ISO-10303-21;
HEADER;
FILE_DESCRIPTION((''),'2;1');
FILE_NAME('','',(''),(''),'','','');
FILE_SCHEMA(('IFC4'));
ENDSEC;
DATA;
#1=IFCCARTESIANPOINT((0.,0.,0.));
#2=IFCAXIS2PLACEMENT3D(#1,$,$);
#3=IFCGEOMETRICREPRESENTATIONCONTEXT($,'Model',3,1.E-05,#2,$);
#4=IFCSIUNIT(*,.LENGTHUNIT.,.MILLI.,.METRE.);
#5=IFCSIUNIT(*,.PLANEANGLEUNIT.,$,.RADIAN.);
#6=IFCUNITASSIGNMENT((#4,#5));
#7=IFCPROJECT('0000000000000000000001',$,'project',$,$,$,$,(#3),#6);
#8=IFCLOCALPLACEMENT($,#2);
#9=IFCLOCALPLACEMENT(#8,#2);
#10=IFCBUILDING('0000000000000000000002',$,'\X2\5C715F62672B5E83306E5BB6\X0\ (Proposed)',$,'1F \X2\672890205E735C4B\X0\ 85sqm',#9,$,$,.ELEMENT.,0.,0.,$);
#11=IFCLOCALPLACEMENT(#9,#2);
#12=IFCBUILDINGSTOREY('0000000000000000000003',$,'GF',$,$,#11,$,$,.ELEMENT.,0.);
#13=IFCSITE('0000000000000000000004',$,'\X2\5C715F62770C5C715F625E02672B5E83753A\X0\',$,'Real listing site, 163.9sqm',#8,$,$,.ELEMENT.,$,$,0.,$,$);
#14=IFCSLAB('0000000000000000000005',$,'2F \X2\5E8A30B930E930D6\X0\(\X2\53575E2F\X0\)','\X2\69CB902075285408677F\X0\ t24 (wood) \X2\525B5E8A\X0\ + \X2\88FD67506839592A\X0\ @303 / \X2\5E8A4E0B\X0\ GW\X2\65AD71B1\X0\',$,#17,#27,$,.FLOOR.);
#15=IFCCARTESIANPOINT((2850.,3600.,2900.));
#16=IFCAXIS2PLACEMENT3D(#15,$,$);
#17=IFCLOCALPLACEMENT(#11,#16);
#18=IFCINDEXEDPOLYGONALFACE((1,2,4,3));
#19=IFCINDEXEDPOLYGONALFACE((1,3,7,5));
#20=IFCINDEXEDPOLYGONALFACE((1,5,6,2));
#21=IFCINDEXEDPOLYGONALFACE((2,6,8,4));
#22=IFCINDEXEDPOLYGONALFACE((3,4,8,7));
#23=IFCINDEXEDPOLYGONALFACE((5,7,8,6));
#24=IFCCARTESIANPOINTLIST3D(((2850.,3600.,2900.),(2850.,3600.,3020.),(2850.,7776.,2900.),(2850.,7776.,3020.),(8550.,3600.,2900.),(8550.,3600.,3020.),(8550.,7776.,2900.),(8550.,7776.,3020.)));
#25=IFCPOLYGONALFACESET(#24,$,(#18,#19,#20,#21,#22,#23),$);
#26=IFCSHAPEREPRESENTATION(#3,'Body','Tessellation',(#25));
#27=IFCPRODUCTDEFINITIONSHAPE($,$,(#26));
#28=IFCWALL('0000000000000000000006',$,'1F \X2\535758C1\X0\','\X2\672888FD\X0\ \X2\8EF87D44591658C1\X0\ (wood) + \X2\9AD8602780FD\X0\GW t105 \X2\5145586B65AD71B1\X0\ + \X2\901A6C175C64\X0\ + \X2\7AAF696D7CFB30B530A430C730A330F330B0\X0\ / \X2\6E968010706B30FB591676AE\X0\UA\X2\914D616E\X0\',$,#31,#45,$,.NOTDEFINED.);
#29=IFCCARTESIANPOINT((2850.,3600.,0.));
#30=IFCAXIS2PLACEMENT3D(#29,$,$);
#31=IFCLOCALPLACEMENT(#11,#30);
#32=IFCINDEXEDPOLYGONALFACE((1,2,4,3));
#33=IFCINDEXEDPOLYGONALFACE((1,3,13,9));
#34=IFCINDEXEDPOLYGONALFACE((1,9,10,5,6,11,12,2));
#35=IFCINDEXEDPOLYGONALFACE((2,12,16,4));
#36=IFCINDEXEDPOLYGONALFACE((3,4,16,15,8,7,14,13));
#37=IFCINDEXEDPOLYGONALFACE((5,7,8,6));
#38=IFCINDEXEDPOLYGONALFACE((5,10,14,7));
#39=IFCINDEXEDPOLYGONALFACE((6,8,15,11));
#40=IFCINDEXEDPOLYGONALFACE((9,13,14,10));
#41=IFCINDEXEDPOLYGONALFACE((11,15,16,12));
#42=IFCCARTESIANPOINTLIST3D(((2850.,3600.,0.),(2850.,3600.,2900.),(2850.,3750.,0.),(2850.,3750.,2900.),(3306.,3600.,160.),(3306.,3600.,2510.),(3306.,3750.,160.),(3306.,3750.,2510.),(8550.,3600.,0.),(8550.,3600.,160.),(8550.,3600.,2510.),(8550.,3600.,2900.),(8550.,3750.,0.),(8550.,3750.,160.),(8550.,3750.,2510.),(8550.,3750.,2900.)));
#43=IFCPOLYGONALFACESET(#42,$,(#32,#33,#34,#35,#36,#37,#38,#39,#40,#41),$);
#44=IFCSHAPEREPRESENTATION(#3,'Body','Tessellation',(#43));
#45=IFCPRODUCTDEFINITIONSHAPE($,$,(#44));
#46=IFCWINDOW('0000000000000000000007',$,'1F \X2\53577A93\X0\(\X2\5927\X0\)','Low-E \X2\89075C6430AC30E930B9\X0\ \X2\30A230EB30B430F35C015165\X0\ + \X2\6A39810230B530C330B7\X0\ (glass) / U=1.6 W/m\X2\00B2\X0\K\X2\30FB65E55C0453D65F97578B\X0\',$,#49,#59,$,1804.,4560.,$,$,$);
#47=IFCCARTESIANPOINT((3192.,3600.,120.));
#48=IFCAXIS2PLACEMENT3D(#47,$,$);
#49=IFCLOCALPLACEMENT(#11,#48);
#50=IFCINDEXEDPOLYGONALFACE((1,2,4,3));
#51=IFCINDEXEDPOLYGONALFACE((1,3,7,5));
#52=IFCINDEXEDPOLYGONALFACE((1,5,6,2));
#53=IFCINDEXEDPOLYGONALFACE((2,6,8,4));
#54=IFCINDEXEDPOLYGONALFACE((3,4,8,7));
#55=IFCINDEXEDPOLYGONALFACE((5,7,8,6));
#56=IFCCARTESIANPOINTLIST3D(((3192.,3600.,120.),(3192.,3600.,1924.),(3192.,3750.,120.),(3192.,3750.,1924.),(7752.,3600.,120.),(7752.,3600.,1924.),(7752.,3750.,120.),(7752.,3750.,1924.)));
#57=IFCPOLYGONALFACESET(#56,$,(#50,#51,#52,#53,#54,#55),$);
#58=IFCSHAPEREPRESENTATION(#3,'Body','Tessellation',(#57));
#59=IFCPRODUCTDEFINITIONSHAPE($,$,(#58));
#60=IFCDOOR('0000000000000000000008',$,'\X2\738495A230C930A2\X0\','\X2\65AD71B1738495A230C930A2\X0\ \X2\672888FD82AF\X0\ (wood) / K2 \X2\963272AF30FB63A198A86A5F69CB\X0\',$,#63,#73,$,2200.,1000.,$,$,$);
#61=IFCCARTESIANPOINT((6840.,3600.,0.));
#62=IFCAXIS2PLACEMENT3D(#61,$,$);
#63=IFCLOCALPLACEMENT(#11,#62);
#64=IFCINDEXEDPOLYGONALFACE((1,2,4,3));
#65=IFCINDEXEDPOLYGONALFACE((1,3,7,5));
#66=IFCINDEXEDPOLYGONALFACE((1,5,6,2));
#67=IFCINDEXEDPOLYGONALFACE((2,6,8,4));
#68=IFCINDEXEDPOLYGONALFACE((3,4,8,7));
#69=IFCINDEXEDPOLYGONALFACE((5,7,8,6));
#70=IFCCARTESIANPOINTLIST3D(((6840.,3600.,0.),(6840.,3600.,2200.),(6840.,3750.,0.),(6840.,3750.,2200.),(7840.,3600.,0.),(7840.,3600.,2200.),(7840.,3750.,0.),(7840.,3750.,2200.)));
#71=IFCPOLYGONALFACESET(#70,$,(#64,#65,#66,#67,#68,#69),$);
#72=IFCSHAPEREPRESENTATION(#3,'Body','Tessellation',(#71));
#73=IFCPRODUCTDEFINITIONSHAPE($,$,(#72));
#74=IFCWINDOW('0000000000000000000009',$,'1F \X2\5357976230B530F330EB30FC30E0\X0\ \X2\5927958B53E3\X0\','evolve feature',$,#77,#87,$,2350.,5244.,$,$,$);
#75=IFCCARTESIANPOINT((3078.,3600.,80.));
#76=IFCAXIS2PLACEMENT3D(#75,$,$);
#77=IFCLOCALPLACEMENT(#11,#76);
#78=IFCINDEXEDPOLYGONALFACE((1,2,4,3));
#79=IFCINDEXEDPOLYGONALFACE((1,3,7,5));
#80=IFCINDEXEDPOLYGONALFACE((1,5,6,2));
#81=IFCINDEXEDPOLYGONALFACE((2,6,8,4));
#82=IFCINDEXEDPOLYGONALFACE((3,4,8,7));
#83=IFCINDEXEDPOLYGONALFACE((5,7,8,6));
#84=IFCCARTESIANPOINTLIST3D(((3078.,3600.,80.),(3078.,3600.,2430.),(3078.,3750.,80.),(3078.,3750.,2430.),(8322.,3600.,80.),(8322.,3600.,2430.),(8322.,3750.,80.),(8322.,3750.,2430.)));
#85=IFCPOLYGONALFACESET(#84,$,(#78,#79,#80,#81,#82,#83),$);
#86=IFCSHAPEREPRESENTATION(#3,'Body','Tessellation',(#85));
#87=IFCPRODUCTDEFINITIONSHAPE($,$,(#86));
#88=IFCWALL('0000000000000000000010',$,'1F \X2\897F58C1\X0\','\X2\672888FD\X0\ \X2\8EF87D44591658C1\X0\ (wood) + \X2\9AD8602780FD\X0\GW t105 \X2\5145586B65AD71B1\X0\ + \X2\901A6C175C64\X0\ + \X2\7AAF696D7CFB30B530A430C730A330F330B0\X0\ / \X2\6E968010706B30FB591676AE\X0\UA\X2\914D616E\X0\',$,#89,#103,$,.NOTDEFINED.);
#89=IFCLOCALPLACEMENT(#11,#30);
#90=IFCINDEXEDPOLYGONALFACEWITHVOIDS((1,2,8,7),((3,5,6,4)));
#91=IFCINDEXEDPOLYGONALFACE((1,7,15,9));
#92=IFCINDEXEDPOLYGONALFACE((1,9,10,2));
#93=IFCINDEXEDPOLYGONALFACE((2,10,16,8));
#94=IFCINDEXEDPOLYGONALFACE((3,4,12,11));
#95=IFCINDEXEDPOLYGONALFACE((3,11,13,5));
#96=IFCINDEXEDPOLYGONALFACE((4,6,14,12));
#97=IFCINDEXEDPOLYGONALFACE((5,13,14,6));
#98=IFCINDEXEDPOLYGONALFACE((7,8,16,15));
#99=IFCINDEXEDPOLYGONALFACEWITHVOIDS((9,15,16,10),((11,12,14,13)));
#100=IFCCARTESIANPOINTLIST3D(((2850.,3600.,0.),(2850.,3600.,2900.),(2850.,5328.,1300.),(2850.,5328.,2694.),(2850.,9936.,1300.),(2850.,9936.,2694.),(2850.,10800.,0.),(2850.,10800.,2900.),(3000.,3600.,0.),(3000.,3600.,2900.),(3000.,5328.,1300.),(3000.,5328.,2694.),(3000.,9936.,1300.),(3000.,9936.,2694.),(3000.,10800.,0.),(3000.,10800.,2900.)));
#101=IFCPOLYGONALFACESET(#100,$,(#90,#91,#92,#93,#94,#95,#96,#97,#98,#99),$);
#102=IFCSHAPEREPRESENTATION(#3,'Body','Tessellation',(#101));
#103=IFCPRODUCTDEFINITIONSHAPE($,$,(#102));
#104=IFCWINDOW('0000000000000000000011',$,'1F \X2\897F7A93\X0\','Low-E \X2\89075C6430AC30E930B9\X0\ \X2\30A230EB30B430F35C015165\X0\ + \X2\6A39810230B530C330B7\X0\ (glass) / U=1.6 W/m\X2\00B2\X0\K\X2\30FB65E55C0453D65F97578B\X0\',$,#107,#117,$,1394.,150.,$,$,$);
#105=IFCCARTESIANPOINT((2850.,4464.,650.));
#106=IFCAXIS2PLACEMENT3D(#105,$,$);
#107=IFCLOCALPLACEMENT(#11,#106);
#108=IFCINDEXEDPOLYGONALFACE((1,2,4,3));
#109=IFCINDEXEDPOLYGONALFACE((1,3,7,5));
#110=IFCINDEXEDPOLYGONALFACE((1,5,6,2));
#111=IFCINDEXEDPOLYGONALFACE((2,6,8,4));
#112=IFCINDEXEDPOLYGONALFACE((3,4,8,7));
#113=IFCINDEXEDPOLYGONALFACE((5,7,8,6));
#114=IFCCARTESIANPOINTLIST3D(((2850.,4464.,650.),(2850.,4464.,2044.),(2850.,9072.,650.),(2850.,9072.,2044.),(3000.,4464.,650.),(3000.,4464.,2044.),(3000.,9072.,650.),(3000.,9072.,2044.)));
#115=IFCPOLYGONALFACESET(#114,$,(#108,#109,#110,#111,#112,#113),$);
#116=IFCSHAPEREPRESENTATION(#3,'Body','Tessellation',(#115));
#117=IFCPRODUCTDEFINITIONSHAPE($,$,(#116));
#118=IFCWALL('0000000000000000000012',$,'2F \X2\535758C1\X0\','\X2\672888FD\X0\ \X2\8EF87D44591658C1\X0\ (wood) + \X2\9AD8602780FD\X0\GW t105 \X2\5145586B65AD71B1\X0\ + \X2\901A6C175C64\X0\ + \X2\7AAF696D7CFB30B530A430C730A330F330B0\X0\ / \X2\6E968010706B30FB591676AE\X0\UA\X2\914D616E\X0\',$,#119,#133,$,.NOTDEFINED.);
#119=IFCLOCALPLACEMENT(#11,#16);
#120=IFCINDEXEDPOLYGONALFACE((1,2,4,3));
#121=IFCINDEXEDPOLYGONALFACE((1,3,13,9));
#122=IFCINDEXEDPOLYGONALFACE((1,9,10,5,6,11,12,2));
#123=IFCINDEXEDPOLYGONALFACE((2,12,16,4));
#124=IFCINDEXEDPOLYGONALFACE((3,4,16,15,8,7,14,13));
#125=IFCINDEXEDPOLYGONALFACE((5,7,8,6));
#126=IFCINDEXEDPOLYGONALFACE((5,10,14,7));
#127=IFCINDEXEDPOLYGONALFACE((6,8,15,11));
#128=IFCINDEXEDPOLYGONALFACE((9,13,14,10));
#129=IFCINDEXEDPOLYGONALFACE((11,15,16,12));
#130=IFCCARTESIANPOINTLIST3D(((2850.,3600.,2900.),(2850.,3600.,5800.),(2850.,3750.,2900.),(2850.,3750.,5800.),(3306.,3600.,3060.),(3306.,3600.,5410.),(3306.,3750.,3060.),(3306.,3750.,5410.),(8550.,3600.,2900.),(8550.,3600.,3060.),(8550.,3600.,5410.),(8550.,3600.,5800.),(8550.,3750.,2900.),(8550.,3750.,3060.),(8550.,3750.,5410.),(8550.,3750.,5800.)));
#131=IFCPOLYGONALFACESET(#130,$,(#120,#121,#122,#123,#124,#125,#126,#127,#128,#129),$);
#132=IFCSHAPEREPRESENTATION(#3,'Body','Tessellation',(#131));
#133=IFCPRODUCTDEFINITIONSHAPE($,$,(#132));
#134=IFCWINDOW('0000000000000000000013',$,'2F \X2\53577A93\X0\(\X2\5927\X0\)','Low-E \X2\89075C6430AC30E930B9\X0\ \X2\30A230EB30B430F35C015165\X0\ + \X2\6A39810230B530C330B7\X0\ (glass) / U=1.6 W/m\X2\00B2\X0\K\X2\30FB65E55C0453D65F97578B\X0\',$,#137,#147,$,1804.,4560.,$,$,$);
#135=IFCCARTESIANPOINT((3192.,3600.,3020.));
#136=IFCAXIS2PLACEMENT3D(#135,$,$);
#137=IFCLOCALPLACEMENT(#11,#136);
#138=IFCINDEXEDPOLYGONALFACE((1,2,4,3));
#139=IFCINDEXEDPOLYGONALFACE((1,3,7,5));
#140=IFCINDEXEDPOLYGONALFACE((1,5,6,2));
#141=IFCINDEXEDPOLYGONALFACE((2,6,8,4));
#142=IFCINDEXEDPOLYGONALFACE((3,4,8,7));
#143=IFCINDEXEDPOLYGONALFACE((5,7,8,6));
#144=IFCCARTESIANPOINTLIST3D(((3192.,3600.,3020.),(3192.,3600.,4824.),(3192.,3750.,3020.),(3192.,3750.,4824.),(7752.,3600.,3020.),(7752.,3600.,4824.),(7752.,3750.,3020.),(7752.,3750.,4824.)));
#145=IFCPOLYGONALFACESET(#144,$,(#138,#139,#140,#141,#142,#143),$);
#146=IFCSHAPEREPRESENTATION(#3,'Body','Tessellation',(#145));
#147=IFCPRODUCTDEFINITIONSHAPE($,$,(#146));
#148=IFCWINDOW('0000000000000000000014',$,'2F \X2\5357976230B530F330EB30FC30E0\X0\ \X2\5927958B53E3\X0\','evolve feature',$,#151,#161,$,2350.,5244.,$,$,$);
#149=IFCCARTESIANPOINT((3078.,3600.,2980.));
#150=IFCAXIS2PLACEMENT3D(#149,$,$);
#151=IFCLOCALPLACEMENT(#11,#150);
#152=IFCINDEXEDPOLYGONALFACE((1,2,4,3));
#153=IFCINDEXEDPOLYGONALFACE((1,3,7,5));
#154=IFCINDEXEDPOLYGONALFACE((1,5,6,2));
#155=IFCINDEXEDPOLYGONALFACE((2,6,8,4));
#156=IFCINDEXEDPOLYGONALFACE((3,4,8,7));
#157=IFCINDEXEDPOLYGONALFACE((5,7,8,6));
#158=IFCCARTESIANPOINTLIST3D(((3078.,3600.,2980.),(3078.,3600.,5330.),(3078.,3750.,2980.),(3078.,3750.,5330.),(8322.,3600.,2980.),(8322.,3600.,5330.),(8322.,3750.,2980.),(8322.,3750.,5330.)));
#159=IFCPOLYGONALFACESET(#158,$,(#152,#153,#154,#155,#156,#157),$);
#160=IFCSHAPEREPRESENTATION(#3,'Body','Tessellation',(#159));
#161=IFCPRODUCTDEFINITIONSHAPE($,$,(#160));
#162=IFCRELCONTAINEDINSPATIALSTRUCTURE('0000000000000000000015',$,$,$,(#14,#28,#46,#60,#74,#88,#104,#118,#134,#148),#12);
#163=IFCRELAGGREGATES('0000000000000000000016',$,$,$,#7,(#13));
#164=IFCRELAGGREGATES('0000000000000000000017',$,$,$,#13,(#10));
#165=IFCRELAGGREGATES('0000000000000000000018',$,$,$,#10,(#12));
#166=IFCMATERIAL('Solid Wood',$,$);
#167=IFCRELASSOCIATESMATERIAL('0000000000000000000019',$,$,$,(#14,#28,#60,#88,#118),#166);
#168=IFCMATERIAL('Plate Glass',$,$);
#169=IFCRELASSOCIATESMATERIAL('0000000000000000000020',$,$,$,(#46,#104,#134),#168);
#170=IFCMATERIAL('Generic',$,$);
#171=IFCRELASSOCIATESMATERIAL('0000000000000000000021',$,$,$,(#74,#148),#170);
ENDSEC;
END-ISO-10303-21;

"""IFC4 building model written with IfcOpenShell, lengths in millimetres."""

from ifc_helpers import new_model, si_unit, frame, frame_2d, origin, place, context, project, spatial, rectangle, extrude, material, element, fill, save


model = new_model("IFC4")

# Units and contexts
model_context = context("Model", 3, precision=1e-05, world=origin())
ifc_project = project(units=[si_unit("LENGTHUNIT", "METRE", prefix="MILLI"), si_unit("PLANEANGLEUNIT", "RADIAN")], contexts=[model_context])

# Site, building, storey
site_placement = place(None, origin())
site = spatial("IfcSite", under=ifc_project, at=site_placement, Name="山形県山形市末広町", ObjectType="Real listing site, 163.9sqm", CompositionType="ELEMENT", RefElevation=0.0)
building_placement = place(site_placement, origin())
building = spatial("IfcBuilding", under=site, at=building_placement, Name="山形末広の家 (Proposed)", ObjectType="1F 木造平屋 85sqm", CompositionType="ELEMENT", ElevationOfRefHeight=0.0, ElevationOfTerrain=0.0)
storey_placement = place(building_placement, origin())
storey = spatial("IfcBuildingStorey", under=building, at=storey_placement, Name="GF", CompositionType="ELEMENT", Elevation=0.0)

# Slab
ifc_material_1 = material(Name="Solid Wood")
slab_1_placement = place(storey_placement, frame((2850.0, 3600.0, 2900.0)))
element("IfcSlab", 1, at=slab_1_placement, inside=storey, material=ifc_material_1, Name="2F 床スラブ(南帯)", Description="構造用合板 t24 (wood) 剛床 + 製材根太 @303 / 床下 GW断熱", PredefinedType="FLOOR", context=model_context, shape_type="SweptSolid", body=[
    extrude(rectangle(XDim=5700.0, YDim=4176.0, at=frame_2d((2850.0, 2088.0))), frame((2850.0, 3600.0, 2900.0)), (0.0, 0.0, 1.0), 120.0),
])
ifc_material_2 = material(Name="Generic")

# Wall, openings, windows, door
wall_1_placement = place(storey_placement, frame((2850.0, 3600.0, 0.0)))
wall_1 = element("IfcWall", 2, at=wall_1_placement, inside=storey, material=ifc_material_1, Name="1F 南壁", Description="木製 軸組外壁 (wood) + 高性能GW t105 充填断熱 + 通気層 + 窯業系サイディング / 準耐火・外皮UA配慮", PredefinedType="NOTDEFINED", context=model_context, shape_type="SweptSolid", body=[
    extrude(rectangle(XDim=5700.0, YDim=150.0, at=frame_2d((2850.0, 75.0))), frame((2850.0, 3600.0, 0.0)), (0.0, 0.0, 1.0), 2900.0),
])
opening_1_placement = place(storey_placement, frame((3192.0, 3600.0, 120.0)))
opening_1 = element("IfcOpeningElement", 3, at=opening_1_placement, cuts=wall_1, PredefinedType="NOTDEFINED", context=model_context, shape_type="SweptSolid", body=[
    extrude(rectangle(XDim=4560.0, YDim=150.0, at=frame_2d((2280.0, 75.0))), frame((3192.0, 3600.0, 120.0)), (0.0, 0.0, 1.0), 1804.0),
])
opening_2_placement = place(storey_placement, frame((6840.0, 3600.0, 0.0)))
opening_2 = element("IfcOpeningElement", 4, at=opening_2_placement, cuts=wall_1, PredefinedType="NOTDEFINED", context=model_context, shape_type="SweptSolid", body=[
    extrude(rectangle(XDim=1000.0, YDim=150.0, at=frame_2d((500.0, 75.0))), frame((6840.0, 3600.0, 0.0)), (0.0, 0.0, 1.0), 2200.0),
])
opening_3_placement = place(storey_placement, frame((3078.0, 3600.0, 80.0)))
opening_3 = element("IfcOpeningElement", 5, at=opening_3_placement, cuts=wall_1, PredefinedType="NOTDEFINED", context=model_context, shape_type="SweptSolid", body=[
    extrude(rectangle(XDim=5244.0, YDim=150.0, at=frame_2d((2622.0, 75.0))), frame((3078.0, 3600.0, 80.0)), (0.0, 0.0, 1.0), 2350.0),
])
ifc_material_3 = material(Name="Plate Glass")
window_1_placement = place(storey_placement, frame((3192.0, 3600.0, 120.0)))
window_1 = element("IfcWindow", 6, at=window_1_placement, inside=storey, material=ifc_material_3, Name="1F 南窓(大)", Description="Low-E 複層ガラス アルゴン封入 + 樹脂サッシ (glass) / U=1.6 W/m²K・日射取得型", OverallHeight=1804.0, OverallWidth=4560.0, context=model_context, shape_type="SweptSolid", body=[
    extrude(rectangle(XDim=4560.0, YDim=150.0, at=frame_2d((2280.0, 75.0))), frame((3192.0, 3600.0, 120.0)), (0.0, 0.0, 1.0), 1804.0),
])
fill(opening_1, window_1)
door_placement = place(storey_placement, frame((6840.0, 3600.0, 0.0)))
door = element("IfcDoor", 7, at=door_placement, inside=storey, material=ifc_material_1, Name="玄関ドア", Description="断熱玄関ドア 木製芯 (wood) / K2 防犯・採風機構", OverallHeight=2200.0, OverallWidth=1000.0, context=model_context, shape_type="SweptSolid", body=[
    extrude(rectangle(XDim=1000.0, YDim=150.0, at=frame_2d((500.0, 75.0))), frame((6840.0, 3600.0, 0.0)), (0.0, 0.0, 1.0), 2200.0),
])
fill(opening_2, door)
window_2_placement = place(storey_placement, frame((3078.0, 3600.0, 80.0)))
window_2 = element("IfcWindow", 8, at=window_2_placement, inside=storey, material=ifc_material_2, Name="1F 南面サンルーム 大開口", Description="evolve feature", OverallHeight=2350.0, OverallWidth=5244.0, context=model_context, shape_type="SweptSolid", body=[
    extrude(rectangle(XDim=5244.0, YDim=150.0, at=frame_2d((2622.0, 75.0))), frame((3078.0, 3600.0, 80.0)), (0.0, 0.0, 1.0), 2350.0),
])
fill(opening_3, window_2)

# Wall, opening, window
wall_2_placement = place(storey_placement, frame((2850.0, 3600.0, 0.0)))
wall_2 = element("IfcWall", 9, at=wall_2_placement, inside=storey, material=ifc_material_1, Name="1F 西壁", Description="木製 軸組外壁 (wood) + 高性能GW t105 充填断熱 + 通気層 + 窯業系サイディング / 準耐火・外皮UA配慮", PredefinedType="NOTDEFINED", context=model_context, shape_type="SweptSolid", body=[
    extrude(rectangle(XDim=150.0, YDim=7200.0, at=frame_2d((75.0, 3600.0))), frame((2850.0, 3600.0, 0.0)), (0.0, 0.0, 1.0), 2900.0),
])
opening_4_placement = place(storey_placement, frame((2850.0, 4464.0, 650.0)))
opening_4 = element("IfcOpeningElement", 10, at=opening_4_placement, cuts=wall_2, PredefinedType="NOTDEFINED", context=model_context, shape_type="SweptSolid", body=[
    extrude(rectangle(XDim=150.0, YDim=4608.0, at=frame_2d((75.0, 2304.0))), frame((2850.0, 4464.0, 650.0)), (0.0, 0.0, 1.0), 1394.0),
])
window_3_placement = place(storey_placement, frame((2850.0, 4464.0, 650.0)))
window_3 = element("IfcWindow", 11, at=window_3_placement, inside=storey, material=ifc_material_3, Name="1F 西窓", Description="Low-E 複層ガラス アルゴン封入 + 樹脂サッシ (glass) / U=1.6 W/m²K・日射取得型", OverallHeight=1394.0, OverallWidth=150.0, context=model_context, shape_type="SweptSolid", body=[
    extrude(rectangle(XDim=150.0, YDim=4608.0, at=frame_2d((75.0, 2304.0))), frame((2850.0, 4464.0, 650.0)), (0.0, 0.0, 1.0), 1394.0),
])
fill(opening_4, window_3)

# Wall, openings, windows
wall_3_placement = place(storey_placement, frame((2850.0, 3600.0, 2900.0)))
wall_3 = element("IfcWall", 12, at=wall_3_placement, inside=storey, material=ifc_material_1, Name="2F 南壁", Description="木製 軸組外壁 (wood) + 高性能GW t105 充填断熱 + 通気層 + 窯業系サイディング / 準耐火・外皮UA配慮", PredefinedType="NOTDEFINED", context=model_context, shape_type="SweptSolid", body=[
    extrude(rectangle(XDim=5700.0, YDim=150.0, at=frame_2d((2850.0, 75.0))), frame((2850.0, 3600.0, 2900.0)), (0.0, 0.0, 1.0), 2900.0),
])
opening_5_placement = place(storey_placement, frame((3192.0, 3600.0, 3020.0)))
opening_5 = element("IfcOpeningElement", 13, at=opening_5_placement, cuts=wall_3, PredefinedType="NOTDEFINED", context=model_context, shape_type="SweptSolid", body=[
    extrude(rectangle(XDim=4560.0, YDim=150.0, at=frame_2d((2280.0, 75.0))), frame((3192.0, 3600.0, 3020.0)), (0.0, 0.0, 1.0), 1804.0),
])
opening_6_placement = place(storey_placement, frame((3078.0, 3600.0, 2980.0)))
opening_6 = element("IfcOpeningElement", 14, at=opening_6_placement, cuts=wall_3, PredefinedType="NOTDEFINED", context=model_context, shape_type="SweptSolid", body=[
    extrude(rectangle(XDim=5244.0, YDim=150.0, at=frame_2d((2622.0, 75.0))), frame((3078.0, 3600.0, 2980.0)), (0.0, 0.0, 1.0), 2350.0),
])
window_4_placement = place(storey_placement, frame((3192.0, 3600.0, 3020.0)))
window_4 = element("IfcWindow", 15, at=window_4_placement, inside=storey, material=ifc_material_3, Name="2F 南窓(大)", Description="Low-E 複層ガラス アルゴン封入 + 樹脂サッシ (glass) / U=1.6 W/m²K・日射取得型", OverallHeight=1804.0, OverallWidth=4560.0, context=model_context, shape_type="SweptSolid", body=[
    extrude(rectangle(XDim=4560.0, YDim=150.0, at=frame_2d((2280.0, 75.0))), frame((3192.0, 3600.0, 3020.0)), (0.0, 0.0, 1.0), 1804.0),
])
fill(opening_5, window_4)
window_5_placement = place(storey_placement, frame((3078.0, 3600.0, 2980.0)))
window_5 = element("IfcWindow", 16, at=window_5_placement, inside=storey, material=ifc_material_2, Name="2F 南面サンルーム 大開口", Description="evolve feature", OverallHeight=2350.0, OverallWidth=5244.0, context=model_context, shape_type="SweptSolid", body=[
    extrude(rectangle(XDim=5244.0, YDim=150.0, at=frame_2d((2622.0, 75.0))), frame((3078.0, 3600.0, 2980.0)), (0.0, 0.0, 1.0), 2350.0),
])
fill(opening_6, window_5)

save(model, "model.ifc")
